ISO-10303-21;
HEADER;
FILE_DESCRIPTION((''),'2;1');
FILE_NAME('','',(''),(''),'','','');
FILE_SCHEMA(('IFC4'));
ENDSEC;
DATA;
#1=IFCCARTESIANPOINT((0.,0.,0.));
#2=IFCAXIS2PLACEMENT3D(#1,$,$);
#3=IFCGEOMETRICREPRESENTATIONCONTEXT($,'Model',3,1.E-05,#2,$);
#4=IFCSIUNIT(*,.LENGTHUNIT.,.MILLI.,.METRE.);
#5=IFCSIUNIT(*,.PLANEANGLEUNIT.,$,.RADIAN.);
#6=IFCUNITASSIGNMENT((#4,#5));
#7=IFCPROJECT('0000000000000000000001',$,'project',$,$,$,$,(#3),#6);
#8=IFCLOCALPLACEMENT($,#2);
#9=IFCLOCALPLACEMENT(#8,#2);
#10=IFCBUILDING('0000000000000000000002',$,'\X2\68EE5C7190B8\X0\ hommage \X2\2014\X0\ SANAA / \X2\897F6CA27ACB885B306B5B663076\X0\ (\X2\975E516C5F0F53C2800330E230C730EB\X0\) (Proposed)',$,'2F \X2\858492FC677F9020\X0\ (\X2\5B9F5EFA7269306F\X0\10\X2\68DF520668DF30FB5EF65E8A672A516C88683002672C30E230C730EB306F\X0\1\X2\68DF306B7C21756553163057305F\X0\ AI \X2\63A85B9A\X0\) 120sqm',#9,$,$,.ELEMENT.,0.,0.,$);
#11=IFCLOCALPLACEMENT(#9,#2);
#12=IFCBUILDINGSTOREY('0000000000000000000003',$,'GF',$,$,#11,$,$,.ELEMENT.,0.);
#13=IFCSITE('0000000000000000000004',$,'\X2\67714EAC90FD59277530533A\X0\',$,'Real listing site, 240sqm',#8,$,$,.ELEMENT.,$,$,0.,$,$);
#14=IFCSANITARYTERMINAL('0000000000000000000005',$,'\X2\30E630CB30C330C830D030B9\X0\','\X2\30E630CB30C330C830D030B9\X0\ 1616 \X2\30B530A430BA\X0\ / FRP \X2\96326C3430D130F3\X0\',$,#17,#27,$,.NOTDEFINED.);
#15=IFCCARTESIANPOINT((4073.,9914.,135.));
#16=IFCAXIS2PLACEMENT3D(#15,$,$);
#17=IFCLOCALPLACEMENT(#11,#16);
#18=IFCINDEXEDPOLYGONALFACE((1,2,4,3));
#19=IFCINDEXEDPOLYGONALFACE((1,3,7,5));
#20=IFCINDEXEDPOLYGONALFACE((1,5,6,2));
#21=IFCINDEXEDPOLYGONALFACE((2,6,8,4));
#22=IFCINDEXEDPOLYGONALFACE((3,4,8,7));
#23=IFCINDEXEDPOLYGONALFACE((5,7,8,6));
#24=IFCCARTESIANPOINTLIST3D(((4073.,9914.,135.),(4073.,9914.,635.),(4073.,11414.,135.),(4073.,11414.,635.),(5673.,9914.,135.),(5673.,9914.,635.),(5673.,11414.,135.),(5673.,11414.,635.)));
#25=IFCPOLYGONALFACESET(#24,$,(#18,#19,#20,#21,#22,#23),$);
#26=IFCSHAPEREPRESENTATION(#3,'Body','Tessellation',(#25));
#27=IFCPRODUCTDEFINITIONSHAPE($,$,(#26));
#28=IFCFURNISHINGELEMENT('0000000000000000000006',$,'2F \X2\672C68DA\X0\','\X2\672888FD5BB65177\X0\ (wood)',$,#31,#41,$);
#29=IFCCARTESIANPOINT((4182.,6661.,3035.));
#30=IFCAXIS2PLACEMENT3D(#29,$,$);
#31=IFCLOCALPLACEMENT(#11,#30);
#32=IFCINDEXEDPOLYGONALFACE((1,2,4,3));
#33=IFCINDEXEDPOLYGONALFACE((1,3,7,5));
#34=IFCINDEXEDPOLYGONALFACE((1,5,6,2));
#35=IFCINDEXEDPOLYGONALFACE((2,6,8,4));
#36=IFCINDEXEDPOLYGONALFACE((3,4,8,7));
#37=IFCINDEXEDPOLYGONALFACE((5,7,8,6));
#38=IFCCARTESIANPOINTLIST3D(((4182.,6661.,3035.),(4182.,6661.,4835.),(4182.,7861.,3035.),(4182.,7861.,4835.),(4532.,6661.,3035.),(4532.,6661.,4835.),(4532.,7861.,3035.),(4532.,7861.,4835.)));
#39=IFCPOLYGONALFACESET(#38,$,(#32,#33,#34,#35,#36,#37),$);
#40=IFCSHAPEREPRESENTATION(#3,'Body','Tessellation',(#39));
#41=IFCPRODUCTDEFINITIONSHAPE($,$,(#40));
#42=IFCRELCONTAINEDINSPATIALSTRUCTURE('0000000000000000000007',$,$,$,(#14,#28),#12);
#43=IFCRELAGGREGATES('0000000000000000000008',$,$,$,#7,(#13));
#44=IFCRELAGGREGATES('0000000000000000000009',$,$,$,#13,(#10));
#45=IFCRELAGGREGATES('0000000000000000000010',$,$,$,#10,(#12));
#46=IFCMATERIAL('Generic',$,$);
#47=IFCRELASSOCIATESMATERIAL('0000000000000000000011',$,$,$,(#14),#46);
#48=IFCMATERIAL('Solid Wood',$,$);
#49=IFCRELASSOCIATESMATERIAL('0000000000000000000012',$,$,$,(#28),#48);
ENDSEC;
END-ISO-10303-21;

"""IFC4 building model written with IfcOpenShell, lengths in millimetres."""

from ifc_helpers import new_model, si_unit, frame, frame_2d, origin, place, context, project, spatial, rectangle, extrude, material, element, save


model = new_model("IFC4")

# Units and contexts
model_context = context("Model", 3, precision=1e-05, world=origin())
ifc_project = project(units=[si_unit("LENGTHUNIT", "METRE", prefix="MILLI"), si_unit("PLANEANGLEUNIT", "RADIAN")], contexts=[model_context])

# Site, building, storey
site_placement = place(None, origin())
site = spatial("IfcSite", under=ifc_project, at=site_placement, Name="東京都大田区", ObjectType="Real listing site, 240sqm", CompositionType="ELEMENT", RefElevation=0.0)
building_placement = place(site_placement, origin())
building = spatial("IfcBuilding", under=site, at=building_placement, Name="森山邸 hommage — SANAA / 西沢立衛に学ぶ (非公式参考モデル) (Proposed)", ObjectType="2F 薄鋼板造 (実建物は10棟分棟・延床未公表。本モデルは1棟に簡略化した AI 推定) 120sqm", CompositionType="ELEMENT", ElevationOfRefHeight=0.0, ElevationOfTerrain=0.0)
storey_placement = place(building_placement, origin())
storey = spatial("IfcBuildingStorey", under=building, at=storey_placement, Name="GF", CompositionType="ELEMENT", Elevation=0.0)

# Shared definitions
ifc_material_1 = material(Name="Solid Wood")

# Shared definitions
ifc_material_2 = material(Name="Generic")

# Sanitary terminal
sanitary_terminal_placement = place(storey_placement, frame((4073.0, 9914.0, 135.0)))
element("IfcSanitaryTerminal", 1, at=sanitary_terminal_placement, inside=storey, material=ifc_material_2, Name="ユニットバス", Description="ユニットバス 1616 サイズ / FRP 防水パン", PredefinedType="NOTDEFINED", context=model_context, shape_type="SweptSolid", body=[
    extrude(rectangle(XDim=1600.0, YDim=1500.0, at=frame_2d((800.0, 750.0))), frame((4073.0, 9914.0, 135.0)), (0.0, 0.0, 1.0), 500.0),
])

# Furnishing element
furnishing_placement = place(storey_placement, frame((4182.0, 6661.0, 3035.0)))
element("IfcFurnishingElement", 2, at=furnishing_placement, inside=storey, material=ifc_material_1, Name="2F 本棚", Description="木製家具 (wood)", context=model_context, shape_type="SweptSolid", body=[
    extrude(rectangle(XDim=350.0, YDim=1200.0, at=frame_2d((175.0, 600.0))), frame((4182.0, 6661.0, 3035.0)), (0.0, 0.0, 1.0), 1800.0),
])

save(model, "model.ifc")
